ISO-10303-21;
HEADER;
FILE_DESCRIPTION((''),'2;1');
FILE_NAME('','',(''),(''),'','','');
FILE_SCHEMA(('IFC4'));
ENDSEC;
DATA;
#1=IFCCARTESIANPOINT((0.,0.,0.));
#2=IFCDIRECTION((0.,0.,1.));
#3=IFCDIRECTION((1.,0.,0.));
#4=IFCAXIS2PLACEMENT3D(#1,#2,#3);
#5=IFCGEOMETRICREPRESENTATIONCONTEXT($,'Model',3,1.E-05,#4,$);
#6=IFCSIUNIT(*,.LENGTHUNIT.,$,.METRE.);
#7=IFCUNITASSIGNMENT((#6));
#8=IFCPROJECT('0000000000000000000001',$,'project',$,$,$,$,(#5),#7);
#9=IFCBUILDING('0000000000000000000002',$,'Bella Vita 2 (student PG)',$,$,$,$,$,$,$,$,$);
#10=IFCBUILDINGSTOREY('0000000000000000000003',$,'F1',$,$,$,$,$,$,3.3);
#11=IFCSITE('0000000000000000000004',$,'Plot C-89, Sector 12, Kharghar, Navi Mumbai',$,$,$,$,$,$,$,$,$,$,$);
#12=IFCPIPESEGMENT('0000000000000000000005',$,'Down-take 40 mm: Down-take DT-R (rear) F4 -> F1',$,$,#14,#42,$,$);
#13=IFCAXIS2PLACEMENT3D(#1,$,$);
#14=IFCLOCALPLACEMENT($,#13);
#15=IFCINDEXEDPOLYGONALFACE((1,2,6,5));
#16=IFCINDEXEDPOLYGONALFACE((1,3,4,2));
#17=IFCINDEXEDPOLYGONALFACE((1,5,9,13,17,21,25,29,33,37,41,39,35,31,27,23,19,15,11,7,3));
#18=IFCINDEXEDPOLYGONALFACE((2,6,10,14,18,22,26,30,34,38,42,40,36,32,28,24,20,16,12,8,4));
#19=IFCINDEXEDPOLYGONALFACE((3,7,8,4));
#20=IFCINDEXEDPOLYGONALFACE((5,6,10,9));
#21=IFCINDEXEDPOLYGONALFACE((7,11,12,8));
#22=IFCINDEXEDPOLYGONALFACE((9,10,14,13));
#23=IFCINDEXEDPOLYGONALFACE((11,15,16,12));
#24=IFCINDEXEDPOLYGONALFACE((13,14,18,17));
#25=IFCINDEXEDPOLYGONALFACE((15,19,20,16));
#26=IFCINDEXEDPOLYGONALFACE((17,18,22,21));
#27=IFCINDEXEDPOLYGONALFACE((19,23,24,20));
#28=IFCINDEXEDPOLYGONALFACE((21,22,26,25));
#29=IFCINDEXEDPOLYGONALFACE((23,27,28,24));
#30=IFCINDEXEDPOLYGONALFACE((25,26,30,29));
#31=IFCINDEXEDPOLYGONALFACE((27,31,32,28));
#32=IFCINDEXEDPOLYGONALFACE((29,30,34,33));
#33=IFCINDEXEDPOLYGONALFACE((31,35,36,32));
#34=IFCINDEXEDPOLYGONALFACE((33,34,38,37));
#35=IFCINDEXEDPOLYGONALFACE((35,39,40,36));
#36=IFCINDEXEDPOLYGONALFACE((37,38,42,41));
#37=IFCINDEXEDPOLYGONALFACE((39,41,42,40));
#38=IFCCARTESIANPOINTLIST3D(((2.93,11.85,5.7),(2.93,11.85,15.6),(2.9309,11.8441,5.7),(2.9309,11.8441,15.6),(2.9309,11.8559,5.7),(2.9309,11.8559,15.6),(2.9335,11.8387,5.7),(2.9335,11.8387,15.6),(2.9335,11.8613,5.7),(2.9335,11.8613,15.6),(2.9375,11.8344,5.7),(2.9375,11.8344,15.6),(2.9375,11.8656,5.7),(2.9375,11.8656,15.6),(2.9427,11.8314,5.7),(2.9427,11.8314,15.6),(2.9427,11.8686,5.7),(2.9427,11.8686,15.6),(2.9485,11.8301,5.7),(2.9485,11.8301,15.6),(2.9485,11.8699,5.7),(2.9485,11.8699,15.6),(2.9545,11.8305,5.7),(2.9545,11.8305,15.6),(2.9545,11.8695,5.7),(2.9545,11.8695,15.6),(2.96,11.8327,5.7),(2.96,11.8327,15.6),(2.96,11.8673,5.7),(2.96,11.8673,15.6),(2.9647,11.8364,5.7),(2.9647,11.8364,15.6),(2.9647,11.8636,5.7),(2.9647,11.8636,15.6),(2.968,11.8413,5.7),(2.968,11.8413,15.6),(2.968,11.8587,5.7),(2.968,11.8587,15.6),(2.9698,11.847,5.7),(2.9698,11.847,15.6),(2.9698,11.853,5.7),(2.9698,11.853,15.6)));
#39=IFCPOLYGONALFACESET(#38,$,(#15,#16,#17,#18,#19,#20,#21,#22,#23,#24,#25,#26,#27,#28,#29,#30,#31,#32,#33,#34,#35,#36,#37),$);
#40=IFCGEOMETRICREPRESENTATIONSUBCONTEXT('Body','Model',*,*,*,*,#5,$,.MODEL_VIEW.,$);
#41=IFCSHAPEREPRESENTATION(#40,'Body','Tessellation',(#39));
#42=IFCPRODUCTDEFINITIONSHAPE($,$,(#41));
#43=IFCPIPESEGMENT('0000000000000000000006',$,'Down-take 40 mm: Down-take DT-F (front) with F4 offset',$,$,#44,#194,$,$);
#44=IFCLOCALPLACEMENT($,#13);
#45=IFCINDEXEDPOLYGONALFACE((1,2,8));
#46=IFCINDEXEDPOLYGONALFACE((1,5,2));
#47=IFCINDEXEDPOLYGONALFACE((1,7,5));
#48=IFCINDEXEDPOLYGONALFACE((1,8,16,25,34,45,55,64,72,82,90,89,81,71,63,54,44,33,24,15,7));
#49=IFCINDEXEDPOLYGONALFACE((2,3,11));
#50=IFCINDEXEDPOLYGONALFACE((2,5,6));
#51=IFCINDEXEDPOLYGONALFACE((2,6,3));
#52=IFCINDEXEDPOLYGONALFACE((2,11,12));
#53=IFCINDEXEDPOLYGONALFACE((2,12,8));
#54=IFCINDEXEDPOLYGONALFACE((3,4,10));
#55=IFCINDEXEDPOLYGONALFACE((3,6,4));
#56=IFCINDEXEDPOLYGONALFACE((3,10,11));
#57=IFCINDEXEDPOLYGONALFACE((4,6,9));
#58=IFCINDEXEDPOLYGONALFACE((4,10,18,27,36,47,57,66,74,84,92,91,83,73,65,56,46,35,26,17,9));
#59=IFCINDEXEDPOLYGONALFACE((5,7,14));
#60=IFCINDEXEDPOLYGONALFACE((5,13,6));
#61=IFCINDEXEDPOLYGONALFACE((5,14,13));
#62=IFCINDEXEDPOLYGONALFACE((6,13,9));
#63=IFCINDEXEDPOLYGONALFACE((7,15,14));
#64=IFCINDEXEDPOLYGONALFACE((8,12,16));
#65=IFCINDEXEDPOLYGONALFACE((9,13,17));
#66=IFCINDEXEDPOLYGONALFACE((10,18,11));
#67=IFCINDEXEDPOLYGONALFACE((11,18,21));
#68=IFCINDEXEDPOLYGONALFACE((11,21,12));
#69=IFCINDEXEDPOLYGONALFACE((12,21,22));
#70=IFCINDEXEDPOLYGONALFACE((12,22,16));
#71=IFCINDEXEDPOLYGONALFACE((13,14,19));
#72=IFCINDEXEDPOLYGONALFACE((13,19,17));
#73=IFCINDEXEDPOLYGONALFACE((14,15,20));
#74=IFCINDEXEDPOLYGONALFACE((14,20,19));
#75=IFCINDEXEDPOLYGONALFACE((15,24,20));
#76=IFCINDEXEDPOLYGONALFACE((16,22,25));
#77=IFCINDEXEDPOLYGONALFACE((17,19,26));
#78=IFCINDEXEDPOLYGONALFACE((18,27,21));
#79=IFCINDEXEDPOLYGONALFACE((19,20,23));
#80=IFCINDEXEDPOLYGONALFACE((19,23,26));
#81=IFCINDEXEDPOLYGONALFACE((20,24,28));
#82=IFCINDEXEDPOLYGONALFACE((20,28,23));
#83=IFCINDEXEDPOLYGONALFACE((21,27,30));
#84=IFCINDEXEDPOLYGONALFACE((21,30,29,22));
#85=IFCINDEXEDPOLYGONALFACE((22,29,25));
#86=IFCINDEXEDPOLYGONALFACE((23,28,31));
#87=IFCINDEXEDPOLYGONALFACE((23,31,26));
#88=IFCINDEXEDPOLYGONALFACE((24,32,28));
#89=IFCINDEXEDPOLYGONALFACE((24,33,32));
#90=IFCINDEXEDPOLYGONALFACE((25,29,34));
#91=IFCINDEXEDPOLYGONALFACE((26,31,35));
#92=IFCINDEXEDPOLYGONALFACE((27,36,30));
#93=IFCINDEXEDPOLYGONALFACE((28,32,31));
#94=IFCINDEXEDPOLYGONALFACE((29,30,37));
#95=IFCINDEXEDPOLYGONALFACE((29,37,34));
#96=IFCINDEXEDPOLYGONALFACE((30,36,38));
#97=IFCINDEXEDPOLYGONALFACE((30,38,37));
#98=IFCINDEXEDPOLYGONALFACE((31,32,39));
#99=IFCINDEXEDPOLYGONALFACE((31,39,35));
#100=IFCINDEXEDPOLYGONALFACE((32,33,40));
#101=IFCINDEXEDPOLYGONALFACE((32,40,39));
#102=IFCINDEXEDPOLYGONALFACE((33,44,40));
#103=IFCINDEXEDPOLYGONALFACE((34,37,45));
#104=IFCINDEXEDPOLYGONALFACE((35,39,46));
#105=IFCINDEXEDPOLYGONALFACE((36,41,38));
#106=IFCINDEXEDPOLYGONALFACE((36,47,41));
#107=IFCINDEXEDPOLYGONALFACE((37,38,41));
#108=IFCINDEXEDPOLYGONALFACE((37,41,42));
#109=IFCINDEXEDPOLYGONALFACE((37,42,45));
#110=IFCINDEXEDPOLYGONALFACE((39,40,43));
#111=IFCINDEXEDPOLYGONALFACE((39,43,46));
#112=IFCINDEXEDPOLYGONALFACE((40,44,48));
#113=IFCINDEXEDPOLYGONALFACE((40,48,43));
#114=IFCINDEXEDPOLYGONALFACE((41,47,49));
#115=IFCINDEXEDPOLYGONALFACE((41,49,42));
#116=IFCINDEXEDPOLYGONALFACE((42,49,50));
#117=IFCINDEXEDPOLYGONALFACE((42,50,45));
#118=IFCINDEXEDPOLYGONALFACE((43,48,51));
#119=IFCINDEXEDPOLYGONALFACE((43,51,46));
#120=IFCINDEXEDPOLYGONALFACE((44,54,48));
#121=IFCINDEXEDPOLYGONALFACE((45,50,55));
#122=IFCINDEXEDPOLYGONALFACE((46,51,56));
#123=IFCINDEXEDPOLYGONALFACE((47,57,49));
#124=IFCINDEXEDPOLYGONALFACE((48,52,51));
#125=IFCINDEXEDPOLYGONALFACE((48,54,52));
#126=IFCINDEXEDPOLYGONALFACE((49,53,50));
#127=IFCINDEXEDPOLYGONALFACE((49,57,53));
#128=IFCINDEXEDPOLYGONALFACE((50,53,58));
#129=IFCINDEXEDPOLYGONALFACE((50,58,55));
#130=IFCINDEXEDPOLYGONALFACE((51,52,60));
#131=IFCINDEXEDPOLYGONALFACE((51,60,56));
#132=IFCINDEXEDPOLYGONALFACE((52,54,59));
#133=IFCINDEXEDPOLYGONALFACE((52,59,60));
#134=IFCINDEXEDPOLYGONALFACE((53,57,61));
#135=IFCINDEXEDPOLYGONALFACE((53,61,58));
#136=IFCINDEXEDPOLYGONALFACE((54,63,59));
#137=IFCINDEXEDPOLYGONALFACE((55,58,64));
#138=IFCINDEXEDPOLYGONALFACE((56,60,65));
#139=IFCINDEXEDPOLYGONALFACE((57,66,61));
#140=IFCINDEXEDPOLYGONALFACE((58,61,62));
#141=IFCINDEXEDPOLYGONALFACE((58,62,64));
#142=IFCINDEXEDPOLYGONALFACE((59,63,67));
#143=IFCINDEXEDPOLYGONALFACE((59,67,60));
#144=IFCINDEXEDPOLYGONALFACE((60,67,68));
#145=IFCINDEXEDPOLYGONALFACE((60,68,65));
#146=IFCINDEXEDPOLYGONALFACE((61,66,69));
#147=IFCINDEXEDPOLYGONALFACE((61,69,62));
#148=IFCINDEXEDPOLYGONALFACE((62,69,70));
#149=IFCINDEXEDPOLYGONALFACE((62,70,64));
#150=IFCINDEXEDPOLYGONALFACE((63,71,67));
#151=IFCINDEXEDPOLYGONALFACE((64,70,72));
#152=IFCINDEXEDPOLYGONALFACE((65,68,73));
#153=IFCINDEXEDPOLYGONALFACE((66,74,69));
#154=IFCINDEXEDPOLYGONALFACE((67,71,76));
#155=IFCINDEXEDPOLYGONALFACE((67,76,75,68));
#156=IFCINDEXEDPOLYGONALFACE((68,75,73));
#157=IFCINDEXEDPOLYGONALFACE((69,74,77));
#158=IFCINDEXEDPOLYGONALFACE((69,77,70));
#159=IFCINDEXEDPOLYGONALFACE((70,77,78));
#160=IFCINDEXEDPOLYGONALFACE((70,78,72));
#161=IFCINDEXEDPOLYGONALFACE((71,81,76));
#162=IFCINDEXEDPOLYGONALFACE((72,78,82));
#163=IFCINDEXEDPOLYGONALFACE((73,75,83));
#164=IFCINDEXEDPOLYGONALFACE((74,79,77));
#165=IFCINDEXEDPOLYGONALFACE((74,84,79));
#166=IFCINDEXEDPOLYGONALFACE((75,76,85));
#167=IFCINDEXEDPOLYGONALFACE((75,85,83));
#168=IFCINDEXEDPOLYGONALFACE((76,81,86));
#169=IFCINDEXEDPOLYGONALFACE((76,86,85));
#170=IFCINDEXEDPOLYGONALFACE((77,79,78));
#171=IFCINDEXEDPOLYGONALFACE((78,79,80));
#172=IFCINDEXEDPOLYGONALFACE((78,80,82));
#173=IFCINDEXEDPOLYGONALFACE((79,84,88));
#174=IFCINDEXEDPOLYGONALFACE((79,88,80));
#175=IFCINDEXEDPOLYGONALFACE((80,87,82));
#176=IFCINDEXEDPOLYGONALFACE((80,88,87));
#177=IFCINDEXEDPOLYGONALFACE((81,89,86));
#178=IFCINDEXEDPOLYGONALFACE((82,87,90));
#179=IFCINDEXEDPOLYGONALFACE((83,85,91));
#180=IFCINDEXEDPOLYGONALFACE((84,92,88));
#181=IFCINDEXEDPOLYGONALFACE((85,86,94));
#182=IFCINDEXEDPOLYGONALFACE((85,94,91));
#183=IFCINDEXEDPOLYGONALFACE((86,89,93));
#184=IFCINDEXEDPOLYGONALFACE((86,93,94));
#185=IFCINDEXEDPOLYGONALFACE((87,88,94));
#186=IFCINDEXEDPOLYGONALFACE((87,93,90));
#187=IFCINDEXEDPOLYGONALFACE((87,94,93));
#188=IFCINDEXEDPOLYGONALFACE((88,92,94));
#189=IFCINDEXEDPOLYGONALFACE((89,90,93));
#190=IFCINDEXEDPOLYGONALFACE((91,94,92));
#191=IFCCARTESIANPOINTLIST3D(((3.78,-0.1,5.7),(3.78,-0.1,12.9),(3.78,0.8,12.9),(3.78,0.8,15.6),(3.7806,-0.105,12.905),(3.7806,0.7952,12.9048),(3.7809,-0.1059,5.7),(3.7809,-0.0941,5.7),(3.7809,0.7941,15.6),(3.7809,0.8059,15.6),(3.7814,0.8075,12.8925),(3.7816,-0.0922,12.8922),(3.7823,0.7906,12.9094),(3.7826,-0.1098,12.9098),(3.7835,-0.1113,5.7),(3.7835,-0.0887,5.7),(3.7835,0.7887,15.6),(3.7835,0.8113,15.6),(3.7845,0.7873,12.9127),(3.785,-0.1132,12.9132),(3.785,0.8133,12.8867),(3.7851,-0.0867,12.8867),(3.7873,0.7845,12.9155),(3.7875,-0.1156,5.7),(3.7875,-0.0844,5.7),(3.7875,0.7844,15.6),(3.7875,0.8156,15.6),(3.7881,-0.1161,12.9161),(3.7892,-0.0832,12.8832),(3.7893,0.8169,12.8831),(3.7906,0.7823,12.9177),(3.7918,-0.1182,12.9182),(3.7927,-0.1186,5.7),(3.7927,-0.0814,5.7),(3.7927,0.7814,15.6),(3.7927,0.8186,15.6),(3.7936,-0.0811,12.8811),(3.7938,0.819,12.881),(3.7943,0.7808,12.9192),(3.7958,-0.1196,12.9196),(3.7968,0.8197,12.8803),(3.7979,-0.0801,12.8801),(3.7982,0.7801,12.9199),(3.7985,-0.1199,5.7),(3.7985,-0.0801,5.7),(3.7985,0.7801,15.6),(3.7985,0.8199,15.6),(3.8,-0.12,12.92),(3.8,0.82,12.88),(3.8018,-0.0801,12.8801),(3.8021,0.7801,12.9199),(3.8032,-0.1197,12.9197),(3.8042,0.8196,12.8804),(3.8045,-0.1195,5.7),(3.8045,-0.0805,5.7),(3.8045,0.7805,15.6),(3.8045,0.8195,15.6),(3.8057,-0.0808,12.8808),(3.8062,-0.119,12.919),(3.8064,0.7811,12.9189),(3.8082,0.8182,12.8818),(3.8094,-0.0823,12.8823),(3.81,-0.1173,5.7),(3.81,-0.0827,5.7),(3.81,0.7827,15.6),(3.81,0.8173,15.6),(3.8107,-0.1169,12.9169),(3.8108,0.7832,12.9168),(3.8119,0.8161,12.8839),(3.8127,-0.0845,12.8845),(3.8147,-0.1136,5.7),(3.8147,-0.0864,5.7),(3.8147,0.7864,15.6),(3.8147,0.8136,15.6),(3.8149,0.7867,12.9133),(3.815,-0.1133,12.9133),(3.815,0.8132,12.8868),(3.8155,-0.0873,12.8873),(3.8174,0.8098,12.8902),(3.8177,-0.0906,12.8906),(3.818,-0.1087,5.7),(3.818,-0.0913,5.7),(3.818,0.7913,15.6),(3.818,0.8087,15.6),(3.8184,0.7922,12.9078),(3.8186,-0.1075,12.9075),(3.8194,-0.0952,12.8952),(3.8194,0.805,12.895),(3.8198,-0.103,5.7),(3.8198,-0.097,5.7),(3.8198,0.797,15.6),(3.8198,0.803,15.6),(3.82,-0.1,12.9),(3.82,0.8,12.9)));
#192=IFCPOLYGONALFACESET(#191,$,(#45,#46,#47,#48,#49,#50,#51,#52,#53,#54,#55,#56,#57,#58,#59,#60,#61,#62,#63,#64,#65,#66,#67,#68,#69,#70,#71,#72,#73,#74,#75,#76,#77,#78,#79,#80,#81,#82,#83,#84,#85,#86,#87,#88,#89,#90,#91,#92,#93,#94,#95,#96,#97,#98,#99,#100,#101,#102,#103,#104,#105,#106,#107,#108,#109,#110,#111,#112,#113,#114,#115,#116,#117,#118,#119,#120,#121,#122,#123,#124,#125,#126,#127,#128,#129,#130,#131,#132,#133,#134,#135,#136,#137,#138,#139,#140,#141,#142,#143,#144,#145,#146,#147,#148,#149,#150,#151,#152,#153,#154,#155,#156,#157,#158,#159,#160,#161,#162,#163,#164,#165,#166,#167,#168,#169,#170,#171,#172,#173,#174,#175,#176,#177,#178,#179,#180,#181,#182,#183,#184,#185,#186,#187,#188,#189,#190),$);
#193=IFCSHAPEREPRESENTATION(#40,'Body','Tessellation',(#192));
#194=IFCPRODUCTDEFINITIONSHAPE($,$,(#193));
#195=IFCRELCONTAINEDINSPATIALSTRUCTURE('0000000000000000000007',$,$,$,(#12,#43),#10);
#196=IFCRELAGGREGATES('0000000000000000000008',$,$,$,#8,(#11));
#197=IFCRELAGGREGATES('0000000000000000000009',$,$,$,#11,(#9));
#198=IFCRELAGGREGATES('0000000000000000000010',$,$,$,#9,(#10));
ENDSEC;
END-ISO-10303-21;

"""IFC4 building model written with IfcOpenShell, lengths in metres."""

from ifc_helpers import new_model, entity, si_unit, origin, origin_with_axes, place, context, subcontext, project, spatial, element, save


model = new_model("IFC4")

# Units and contexts
model_context = context("Model", 3, precision=1e-05, world=origin_with_axes())
body_context = subcontext(model_context, "Body", "Model", "MODEL_VIEW")
ifc_project = project(units=[si_unit("LENGTHUNIT", "METRE")], contexts=[model_context])

# Site, building, storey
site = spatial("IfcSite", under=ifc_project, Name="Plot C-89, Sector 12, Kharghar, Navi Mumbai")
building = spatial("IfcBuilding", under=site, Name="Bella Vita 2 (student PG)")
storey = spatial("IfcBuildingStorey", under=building, Name="F1", Elevation=3.3)

# Pipe segments
pipe_segment_1_placement = place(None, origin())
element("IfcPipeSegment", 1, at=pipe_segment_1_placement, inside=storey, Name="Down-take 40 mm: Down-take DT-R (rear) F4 -> F1", context=body_context, shape_type="AdvancedSweptSolid", body=[
    entity("IfcSweptDiskSolid", entity("IfcPolyline", [entity("IfcCartesianPoint", [2.95, 11.85, 15.6]), entity("IfcCartesianPoint", [2.95, 11.85, 5.7])]), 0.02),
])
pipe_segment_2_placement = place(None, origin())
element("IfcPipeSegment", 2, at=pipe_segment_2_placement, inside=storey, Name="Down-take 40 mm: Down-take DT-F (front) with F4 offset", context=body_context, shape_type="AdvancedSweptSolid", body=[
    entity("IfcSweptDiskSolid", entity("IfcPolyline", [entity("IfcCartesianPoint", [3.8, 0.8, 15.6]), entity("IfcCartesianPoint", [3.8, 0.8, 12.9]), entity("IfcCartesianPoint", [3.8, -0.1, 12.9]), entity("IfcCartesianPoint", [3.8, -0.1, 5.7])]), 0.02),
])

save(model, "model.ifc")
